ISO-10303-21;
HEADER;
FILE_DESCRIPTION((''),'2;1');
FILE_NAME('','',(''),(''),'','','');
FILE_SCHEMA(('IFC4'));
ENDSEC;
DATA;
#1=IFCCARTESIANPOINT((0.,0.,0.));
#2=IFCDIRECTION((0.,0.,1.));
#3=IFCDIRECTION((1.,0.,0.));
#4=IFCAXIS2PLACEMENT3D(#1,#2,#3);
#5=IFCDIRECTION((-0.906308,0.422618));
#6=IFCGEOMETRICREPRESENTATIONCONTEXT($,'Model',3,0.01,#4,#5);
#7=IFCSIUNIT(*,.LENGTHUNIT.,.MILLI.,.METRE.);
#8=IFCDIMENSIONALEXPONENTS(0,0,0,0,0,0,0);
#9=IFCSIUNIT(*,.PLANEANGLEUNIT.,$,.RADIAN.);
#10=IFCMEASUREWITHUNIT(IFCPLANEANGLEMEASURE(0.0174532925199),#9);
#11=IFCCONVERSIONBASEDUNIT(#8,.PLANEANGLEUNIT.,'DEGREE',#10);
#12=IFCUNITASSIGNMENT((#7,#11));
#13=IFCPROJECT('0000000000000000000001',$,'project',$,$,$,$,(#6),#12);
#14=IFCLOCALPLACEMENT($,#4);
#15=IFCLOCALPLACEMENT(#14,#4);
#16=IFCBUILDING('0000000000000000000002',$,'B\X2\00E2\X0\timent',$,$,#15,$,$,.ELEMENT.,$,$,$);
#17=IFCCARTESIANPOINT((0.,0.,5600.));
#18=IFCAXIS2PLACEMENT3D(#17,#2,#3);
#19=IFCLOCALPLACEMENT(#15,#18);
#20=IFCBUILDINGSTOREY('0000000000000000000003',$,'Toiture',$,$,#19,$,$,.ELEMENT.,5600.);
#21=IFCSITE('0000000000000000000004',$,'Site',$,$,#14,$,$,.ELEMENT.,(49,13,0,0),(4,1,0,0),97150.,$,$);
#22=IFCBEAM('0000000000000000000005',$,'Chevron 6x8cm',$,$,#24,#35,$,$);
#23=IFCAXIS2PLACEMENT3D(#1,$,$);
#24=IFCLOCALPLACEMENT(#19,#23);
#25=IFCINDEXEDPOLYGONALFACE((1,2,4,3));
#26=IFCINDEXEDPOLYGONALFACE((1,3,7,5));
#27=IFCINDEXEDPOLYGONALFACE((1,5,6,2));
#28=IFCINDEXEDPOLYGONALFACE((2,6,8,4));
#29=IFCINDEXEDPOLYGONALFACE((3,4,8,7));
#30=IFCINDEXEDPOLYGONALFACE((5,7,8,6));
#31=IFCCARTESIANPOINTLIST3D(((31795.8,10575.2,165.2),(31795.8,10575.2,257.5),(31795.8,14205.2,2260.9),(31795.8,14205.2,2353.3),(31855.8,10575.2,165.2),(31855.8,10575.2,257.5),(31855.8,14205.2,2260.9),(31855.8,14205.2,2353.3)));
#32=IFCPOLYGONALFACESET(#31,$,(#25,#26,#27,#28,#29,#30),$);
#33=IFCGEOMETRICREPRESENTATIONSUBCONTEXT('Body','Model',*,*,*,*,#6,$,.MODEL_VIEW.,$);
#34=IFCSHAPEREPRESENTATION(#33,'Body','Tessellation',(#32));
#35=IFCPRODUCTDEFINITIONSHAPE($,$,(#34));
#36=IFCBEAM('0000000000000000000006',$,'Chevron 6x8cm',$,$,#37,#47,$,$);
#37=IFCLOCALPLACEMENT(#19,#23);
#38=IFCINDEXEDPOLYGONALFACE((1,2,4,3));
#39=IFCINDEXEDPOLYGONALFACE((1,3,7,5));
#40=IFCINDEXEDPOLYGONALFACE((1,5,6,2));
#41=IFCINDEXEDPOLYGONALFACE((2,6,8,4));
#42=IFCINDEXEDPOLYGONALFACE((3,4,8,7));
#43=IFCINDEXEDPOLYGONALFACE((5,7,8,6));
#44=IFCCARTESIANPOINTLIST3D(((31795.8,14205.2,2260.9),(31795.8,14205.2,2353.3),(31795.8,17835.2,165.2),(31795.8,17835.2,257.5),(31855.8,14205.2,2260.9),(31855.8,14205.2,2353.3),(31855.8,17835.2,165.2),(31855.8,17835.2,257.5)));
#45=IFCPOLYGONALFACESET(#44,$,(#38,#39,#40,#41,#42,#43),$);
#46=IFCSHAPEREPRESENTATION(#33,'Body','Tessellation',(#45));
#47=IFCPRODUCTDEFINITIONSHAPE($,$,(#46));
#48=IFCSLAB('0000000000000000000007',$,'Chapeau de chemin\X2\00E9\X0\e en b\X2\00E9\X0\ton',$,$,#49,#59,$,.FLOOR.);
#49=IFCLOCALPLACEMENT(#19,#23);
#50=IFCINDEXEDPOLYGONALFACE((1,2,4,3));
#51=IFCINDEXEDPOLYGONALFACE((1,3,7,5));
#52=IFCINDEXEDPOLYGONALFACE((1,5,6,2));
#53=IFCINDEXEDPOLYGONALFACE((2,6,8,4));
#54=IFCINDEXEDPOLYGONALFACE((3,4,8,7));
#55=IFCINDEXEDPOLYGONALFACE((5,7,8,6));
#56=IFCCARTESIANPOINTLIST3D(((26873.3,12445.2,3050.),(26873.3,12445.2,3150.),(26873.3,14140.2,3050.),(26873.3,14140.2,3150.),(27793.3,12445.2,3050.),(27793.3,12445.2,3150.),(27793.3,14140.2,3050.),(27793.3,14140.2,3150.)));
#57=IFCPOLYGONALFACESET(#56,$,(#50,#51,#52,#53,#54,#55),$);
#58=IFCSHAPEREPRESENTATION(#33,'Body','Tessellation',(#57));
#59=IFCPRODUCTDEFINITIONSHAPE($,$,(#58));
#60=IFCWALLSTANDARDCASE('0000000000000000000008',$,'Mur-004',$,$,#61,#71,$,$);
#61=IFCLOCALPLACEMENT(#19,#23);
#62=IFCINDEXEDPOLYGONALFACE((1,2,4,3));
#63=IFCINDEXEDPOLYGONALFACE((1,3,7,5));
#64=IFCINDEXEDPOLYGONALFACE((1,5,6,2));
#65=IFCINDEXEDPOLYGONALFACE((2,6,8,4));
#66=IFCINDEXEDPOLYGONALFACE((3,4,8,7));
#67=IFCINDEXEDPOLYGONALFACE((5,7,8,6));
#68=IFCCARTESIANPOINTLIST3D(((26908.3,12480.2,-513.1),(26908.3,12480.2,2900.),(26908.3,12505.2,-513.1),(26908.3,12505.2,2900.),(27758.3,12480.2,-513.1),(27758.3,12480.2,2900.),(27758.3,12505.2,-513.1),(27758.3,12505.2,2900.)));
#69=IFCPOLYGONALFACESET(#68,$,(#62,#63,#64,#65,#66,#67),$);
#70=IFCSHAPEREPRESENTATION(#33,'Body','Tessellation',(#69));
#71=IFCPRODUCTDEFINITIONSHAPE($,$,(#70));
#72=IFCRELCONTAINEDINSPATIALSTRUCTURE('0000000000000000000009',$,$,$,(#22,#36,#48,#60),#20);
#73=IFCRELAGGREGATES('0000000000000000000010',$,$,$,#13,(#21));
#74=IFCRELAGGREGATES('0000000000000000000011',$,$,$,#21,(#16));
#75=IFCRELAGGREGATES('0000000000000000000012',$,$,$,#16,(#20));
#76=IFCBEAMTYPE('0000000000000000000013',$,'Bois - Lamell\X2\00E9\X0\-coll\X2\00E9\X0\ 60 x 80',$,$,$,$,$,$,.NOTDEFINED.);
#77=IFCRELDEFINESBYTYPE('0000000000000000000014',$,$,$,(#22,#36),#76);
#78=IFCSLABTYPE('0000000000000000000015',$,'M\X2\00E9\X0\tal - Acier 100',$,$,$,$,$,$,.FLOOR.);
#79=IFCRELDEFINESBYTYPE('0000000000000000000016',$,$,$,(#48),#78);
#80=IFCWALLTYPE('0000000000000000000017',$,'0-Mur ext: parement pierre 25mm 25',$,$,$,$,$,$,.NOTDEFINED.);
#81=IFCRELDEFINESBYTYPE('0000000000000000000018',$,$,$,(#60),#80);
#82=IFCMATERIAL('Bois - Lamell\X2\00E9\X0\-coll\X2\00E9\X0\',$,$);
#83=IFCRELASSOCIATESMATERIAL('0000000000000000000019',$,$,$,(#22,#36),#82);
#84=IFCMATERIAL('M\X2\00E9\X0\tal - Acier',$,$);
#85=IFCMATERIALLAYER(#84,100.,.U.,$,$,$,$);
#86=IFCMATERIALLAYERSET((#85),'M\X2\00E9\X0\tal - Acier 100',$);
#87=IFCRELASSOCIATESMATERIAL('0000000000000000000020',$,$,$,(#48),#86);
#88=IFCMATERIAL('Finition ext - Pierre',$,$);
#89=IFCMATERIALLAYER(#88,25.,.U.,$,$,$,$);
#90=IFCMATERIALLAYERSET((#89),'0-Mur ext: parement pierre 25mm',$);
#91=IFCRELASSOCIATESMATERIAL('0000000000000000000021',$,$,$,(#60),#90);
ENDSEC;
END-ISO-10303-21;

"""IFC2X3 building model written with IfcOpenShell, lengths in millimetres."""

from ifc_helpers import new_model, entity, si_unit, converted_unit, direction, frame, frame_2d, origin_with_axes, place, context, subcontext, project, spatial, polyline, rectangle, outline, extrude, clip, halfspace, material, layer, layer_set, layer_usage, type_object, element, save


model = new_model("IFC2X3")

# Units and contexts
model_context = context("Model", 3, precision=0.01, world=origin_with_axes(), true_north=direction((-0.906308, 0.422618)))
body_context = subcontext(model_context, "Body", "Model", "MODEL_VIEW")
ifc_project = project(units=[si_unit("LENGTHUNIT", "METRE", prefix="MILLI"), converted_unit("PLANEANGLEUNIT", "DEGREE", entity("IfcPlaneAngleMeasure", 0.0174532925199), si_unit("PLANEANGLEUNIT", "RADIAN"), dimensions=[0, 0, 0, 0, 0, 0, 0])], contexts=[model_context])

# Site, building, storey
site_placement = place(None, origin_with_axes())
site = spatial("IfcSite", under=ifc_project, at=site_placement, Name="Site", CompositionType="ELEMENT", RefLatitude=(49, 13, 0, 0), RefLongitude=(4, 1, 0, 0), RefElevation=97150.0)
building_placement = place(site_placement, origin_with_axes())
building = spatial("IfcBuilding", under=site, at=building_placement, Name="Bâtiment", CompositionType="ELEMENT")
storey_placement = place(building_placement, frame((0.0, 0.0, 5600.0), z_axis=(0.0, 0.0, 1.0), x_axis=(1.0, 0.0, 0.0)))
storey = spatial("IfcBuildingStorey", under=building, at=storey_placement, Name="Toiture", CompositionType="ELEMENT", Elevation=5600.0)

# Beams
ifc_material_1 = material(Name="Bois - Lamellé-collé")
beam_type_1 = type_object("IfcBeamType", Name="Bois - Lamellé-collé 60 x 80", PredefinedType="NOTDEFINED")
for number, where, z_axis, x_axis, name in (
    (1, (31825.8, 10575.2, 257.5), (0.0, 0.0, 1.0), (1.0, 0.0, 0.0), "Chevron 6x8cm"),
    (2, (31825.8, 17835.2, 257.5), (0.0, 0.0, 1.0), (-1.0, 0.0, 0.0), "Chevron 6x8cm"),
):
    element("IfcBeam", number, at=place(storey_placement, frame(where, z_axis=z_axis, x_axis=x_axis)), inside=storey, type_object=beam_type_1, material=ifc_material_1, Name=name, context=body_context, shape_type="Clipping", body=[
        clip(clip(extrude(rectangle(XDim=80.0, YDim=60.0, at=frame_2d((-40.0, 0.0), x_axis=(1.0, 0.0))), frame((0.0, -56.6, -32.7), z_axis=(0.0, 0.866025, 0.5), x_axis=(0.0, -0.5, 0.866025)), (0.0, 0.0, 1.0), 4322.2), halfspace(frame((0.0, 0.0, 0.0), z_axis=(0.0, 1.0, 0.0), x_axis=(0.0, 0.0, 1.0)), True)), halfspace(frame((0.0, 3630.0, 0.0), z_axis=(0.0, -1.0, 0.0), x_axis=(0.0, 0.0, -1.0)), True)),
    ])

# Slab
ifc_material_2 = material(Name="Métal - Acier")
ifc_layer_1 = layer(ifc_material_2, 100.0, ventilated="UNKNOWN")
ifc_layer_set_1 = layer_set([ifc_layer_1], Name="Métal - Acier 100")
ifc_layer_usage_1 = layer_usage(ifc_layer_set_1, "AXIS3", "NEGATIVE", 100.0)
slab_type_1 = type_object("IfcSlabType", Name="Métal - Acier 100", PredefinedType="FLOOR")
slab_1_placement = place(storey_placement, frame((26873.3, 14140.2, 3150.0), z_axis=(0.0, 0.0, 1.0), x_axis=(1.0, 0.0, 0.0)))
element("IfcSlab", 3, at=slab_1_placement, inside=storey, type_object=slab_type_1, material=ifc_layer_usage_1, Name="Chapeau de cheminée en béton", PredefinedType="FLOOR", context=body_context, shape_type="SweptSolid", body=[
    extrude(outline(polyline([(0.0, 0.0), (0.0, -1695.0), (920.0, -1695.0), (920.0, 0.0), (0.0, 0.0)])), frame((0.0, 0.0, -100.0), z_axis=(0.0, 0.0, 1.0), x_axis=(1.0, 0.0, 0.0)), (0.0, 0.0, 1.0), 100.0),
])

# Wall
ifc_material_3 = material(Name="Finition ext - Pierre")
ifc_layer_2 = layer(ifc_material_3, 25.0, ventilated="UNKNOWN")
ifc_layer_set_2 = layer_set([ifc_layer_2], Name="0-Mur ext: parement pierre 25mm")
ifc_layer_usage_2 = layer_usage(ifc_layer_set_2, "AXIS2", "POSITIVE", -25.0)
wall_type = type_object("IfcWallType", Name="0-Mur ext: parement pierre 25mm 25", PredefinedType="NOTDEFINED")
wall_placement = place(storey_placement, frame((27758.3, 12480.2, -513.1), z_axis=(0.0, 0.0, 1.0), x_axis=(-1.0, 0.0, 0.0)))
element("IfcWallStandardCase", 4, at=wall_placement, inside=storey, type_object=wall_type, material=ifc_layer_usage_2, Name="Mur-004", context=body_context, shape_type="SweptSolid", body=[
    extrude(outline(polyline([(0.0, -25.0), (850.0, -25.0), (850.0, 0.0), (0.0, 0.0), (0.0, -25.0)])), origin_with_axes(), (0.0, 0.0, 1.0), 3413.1),
])

save(model, "model.ifc")
